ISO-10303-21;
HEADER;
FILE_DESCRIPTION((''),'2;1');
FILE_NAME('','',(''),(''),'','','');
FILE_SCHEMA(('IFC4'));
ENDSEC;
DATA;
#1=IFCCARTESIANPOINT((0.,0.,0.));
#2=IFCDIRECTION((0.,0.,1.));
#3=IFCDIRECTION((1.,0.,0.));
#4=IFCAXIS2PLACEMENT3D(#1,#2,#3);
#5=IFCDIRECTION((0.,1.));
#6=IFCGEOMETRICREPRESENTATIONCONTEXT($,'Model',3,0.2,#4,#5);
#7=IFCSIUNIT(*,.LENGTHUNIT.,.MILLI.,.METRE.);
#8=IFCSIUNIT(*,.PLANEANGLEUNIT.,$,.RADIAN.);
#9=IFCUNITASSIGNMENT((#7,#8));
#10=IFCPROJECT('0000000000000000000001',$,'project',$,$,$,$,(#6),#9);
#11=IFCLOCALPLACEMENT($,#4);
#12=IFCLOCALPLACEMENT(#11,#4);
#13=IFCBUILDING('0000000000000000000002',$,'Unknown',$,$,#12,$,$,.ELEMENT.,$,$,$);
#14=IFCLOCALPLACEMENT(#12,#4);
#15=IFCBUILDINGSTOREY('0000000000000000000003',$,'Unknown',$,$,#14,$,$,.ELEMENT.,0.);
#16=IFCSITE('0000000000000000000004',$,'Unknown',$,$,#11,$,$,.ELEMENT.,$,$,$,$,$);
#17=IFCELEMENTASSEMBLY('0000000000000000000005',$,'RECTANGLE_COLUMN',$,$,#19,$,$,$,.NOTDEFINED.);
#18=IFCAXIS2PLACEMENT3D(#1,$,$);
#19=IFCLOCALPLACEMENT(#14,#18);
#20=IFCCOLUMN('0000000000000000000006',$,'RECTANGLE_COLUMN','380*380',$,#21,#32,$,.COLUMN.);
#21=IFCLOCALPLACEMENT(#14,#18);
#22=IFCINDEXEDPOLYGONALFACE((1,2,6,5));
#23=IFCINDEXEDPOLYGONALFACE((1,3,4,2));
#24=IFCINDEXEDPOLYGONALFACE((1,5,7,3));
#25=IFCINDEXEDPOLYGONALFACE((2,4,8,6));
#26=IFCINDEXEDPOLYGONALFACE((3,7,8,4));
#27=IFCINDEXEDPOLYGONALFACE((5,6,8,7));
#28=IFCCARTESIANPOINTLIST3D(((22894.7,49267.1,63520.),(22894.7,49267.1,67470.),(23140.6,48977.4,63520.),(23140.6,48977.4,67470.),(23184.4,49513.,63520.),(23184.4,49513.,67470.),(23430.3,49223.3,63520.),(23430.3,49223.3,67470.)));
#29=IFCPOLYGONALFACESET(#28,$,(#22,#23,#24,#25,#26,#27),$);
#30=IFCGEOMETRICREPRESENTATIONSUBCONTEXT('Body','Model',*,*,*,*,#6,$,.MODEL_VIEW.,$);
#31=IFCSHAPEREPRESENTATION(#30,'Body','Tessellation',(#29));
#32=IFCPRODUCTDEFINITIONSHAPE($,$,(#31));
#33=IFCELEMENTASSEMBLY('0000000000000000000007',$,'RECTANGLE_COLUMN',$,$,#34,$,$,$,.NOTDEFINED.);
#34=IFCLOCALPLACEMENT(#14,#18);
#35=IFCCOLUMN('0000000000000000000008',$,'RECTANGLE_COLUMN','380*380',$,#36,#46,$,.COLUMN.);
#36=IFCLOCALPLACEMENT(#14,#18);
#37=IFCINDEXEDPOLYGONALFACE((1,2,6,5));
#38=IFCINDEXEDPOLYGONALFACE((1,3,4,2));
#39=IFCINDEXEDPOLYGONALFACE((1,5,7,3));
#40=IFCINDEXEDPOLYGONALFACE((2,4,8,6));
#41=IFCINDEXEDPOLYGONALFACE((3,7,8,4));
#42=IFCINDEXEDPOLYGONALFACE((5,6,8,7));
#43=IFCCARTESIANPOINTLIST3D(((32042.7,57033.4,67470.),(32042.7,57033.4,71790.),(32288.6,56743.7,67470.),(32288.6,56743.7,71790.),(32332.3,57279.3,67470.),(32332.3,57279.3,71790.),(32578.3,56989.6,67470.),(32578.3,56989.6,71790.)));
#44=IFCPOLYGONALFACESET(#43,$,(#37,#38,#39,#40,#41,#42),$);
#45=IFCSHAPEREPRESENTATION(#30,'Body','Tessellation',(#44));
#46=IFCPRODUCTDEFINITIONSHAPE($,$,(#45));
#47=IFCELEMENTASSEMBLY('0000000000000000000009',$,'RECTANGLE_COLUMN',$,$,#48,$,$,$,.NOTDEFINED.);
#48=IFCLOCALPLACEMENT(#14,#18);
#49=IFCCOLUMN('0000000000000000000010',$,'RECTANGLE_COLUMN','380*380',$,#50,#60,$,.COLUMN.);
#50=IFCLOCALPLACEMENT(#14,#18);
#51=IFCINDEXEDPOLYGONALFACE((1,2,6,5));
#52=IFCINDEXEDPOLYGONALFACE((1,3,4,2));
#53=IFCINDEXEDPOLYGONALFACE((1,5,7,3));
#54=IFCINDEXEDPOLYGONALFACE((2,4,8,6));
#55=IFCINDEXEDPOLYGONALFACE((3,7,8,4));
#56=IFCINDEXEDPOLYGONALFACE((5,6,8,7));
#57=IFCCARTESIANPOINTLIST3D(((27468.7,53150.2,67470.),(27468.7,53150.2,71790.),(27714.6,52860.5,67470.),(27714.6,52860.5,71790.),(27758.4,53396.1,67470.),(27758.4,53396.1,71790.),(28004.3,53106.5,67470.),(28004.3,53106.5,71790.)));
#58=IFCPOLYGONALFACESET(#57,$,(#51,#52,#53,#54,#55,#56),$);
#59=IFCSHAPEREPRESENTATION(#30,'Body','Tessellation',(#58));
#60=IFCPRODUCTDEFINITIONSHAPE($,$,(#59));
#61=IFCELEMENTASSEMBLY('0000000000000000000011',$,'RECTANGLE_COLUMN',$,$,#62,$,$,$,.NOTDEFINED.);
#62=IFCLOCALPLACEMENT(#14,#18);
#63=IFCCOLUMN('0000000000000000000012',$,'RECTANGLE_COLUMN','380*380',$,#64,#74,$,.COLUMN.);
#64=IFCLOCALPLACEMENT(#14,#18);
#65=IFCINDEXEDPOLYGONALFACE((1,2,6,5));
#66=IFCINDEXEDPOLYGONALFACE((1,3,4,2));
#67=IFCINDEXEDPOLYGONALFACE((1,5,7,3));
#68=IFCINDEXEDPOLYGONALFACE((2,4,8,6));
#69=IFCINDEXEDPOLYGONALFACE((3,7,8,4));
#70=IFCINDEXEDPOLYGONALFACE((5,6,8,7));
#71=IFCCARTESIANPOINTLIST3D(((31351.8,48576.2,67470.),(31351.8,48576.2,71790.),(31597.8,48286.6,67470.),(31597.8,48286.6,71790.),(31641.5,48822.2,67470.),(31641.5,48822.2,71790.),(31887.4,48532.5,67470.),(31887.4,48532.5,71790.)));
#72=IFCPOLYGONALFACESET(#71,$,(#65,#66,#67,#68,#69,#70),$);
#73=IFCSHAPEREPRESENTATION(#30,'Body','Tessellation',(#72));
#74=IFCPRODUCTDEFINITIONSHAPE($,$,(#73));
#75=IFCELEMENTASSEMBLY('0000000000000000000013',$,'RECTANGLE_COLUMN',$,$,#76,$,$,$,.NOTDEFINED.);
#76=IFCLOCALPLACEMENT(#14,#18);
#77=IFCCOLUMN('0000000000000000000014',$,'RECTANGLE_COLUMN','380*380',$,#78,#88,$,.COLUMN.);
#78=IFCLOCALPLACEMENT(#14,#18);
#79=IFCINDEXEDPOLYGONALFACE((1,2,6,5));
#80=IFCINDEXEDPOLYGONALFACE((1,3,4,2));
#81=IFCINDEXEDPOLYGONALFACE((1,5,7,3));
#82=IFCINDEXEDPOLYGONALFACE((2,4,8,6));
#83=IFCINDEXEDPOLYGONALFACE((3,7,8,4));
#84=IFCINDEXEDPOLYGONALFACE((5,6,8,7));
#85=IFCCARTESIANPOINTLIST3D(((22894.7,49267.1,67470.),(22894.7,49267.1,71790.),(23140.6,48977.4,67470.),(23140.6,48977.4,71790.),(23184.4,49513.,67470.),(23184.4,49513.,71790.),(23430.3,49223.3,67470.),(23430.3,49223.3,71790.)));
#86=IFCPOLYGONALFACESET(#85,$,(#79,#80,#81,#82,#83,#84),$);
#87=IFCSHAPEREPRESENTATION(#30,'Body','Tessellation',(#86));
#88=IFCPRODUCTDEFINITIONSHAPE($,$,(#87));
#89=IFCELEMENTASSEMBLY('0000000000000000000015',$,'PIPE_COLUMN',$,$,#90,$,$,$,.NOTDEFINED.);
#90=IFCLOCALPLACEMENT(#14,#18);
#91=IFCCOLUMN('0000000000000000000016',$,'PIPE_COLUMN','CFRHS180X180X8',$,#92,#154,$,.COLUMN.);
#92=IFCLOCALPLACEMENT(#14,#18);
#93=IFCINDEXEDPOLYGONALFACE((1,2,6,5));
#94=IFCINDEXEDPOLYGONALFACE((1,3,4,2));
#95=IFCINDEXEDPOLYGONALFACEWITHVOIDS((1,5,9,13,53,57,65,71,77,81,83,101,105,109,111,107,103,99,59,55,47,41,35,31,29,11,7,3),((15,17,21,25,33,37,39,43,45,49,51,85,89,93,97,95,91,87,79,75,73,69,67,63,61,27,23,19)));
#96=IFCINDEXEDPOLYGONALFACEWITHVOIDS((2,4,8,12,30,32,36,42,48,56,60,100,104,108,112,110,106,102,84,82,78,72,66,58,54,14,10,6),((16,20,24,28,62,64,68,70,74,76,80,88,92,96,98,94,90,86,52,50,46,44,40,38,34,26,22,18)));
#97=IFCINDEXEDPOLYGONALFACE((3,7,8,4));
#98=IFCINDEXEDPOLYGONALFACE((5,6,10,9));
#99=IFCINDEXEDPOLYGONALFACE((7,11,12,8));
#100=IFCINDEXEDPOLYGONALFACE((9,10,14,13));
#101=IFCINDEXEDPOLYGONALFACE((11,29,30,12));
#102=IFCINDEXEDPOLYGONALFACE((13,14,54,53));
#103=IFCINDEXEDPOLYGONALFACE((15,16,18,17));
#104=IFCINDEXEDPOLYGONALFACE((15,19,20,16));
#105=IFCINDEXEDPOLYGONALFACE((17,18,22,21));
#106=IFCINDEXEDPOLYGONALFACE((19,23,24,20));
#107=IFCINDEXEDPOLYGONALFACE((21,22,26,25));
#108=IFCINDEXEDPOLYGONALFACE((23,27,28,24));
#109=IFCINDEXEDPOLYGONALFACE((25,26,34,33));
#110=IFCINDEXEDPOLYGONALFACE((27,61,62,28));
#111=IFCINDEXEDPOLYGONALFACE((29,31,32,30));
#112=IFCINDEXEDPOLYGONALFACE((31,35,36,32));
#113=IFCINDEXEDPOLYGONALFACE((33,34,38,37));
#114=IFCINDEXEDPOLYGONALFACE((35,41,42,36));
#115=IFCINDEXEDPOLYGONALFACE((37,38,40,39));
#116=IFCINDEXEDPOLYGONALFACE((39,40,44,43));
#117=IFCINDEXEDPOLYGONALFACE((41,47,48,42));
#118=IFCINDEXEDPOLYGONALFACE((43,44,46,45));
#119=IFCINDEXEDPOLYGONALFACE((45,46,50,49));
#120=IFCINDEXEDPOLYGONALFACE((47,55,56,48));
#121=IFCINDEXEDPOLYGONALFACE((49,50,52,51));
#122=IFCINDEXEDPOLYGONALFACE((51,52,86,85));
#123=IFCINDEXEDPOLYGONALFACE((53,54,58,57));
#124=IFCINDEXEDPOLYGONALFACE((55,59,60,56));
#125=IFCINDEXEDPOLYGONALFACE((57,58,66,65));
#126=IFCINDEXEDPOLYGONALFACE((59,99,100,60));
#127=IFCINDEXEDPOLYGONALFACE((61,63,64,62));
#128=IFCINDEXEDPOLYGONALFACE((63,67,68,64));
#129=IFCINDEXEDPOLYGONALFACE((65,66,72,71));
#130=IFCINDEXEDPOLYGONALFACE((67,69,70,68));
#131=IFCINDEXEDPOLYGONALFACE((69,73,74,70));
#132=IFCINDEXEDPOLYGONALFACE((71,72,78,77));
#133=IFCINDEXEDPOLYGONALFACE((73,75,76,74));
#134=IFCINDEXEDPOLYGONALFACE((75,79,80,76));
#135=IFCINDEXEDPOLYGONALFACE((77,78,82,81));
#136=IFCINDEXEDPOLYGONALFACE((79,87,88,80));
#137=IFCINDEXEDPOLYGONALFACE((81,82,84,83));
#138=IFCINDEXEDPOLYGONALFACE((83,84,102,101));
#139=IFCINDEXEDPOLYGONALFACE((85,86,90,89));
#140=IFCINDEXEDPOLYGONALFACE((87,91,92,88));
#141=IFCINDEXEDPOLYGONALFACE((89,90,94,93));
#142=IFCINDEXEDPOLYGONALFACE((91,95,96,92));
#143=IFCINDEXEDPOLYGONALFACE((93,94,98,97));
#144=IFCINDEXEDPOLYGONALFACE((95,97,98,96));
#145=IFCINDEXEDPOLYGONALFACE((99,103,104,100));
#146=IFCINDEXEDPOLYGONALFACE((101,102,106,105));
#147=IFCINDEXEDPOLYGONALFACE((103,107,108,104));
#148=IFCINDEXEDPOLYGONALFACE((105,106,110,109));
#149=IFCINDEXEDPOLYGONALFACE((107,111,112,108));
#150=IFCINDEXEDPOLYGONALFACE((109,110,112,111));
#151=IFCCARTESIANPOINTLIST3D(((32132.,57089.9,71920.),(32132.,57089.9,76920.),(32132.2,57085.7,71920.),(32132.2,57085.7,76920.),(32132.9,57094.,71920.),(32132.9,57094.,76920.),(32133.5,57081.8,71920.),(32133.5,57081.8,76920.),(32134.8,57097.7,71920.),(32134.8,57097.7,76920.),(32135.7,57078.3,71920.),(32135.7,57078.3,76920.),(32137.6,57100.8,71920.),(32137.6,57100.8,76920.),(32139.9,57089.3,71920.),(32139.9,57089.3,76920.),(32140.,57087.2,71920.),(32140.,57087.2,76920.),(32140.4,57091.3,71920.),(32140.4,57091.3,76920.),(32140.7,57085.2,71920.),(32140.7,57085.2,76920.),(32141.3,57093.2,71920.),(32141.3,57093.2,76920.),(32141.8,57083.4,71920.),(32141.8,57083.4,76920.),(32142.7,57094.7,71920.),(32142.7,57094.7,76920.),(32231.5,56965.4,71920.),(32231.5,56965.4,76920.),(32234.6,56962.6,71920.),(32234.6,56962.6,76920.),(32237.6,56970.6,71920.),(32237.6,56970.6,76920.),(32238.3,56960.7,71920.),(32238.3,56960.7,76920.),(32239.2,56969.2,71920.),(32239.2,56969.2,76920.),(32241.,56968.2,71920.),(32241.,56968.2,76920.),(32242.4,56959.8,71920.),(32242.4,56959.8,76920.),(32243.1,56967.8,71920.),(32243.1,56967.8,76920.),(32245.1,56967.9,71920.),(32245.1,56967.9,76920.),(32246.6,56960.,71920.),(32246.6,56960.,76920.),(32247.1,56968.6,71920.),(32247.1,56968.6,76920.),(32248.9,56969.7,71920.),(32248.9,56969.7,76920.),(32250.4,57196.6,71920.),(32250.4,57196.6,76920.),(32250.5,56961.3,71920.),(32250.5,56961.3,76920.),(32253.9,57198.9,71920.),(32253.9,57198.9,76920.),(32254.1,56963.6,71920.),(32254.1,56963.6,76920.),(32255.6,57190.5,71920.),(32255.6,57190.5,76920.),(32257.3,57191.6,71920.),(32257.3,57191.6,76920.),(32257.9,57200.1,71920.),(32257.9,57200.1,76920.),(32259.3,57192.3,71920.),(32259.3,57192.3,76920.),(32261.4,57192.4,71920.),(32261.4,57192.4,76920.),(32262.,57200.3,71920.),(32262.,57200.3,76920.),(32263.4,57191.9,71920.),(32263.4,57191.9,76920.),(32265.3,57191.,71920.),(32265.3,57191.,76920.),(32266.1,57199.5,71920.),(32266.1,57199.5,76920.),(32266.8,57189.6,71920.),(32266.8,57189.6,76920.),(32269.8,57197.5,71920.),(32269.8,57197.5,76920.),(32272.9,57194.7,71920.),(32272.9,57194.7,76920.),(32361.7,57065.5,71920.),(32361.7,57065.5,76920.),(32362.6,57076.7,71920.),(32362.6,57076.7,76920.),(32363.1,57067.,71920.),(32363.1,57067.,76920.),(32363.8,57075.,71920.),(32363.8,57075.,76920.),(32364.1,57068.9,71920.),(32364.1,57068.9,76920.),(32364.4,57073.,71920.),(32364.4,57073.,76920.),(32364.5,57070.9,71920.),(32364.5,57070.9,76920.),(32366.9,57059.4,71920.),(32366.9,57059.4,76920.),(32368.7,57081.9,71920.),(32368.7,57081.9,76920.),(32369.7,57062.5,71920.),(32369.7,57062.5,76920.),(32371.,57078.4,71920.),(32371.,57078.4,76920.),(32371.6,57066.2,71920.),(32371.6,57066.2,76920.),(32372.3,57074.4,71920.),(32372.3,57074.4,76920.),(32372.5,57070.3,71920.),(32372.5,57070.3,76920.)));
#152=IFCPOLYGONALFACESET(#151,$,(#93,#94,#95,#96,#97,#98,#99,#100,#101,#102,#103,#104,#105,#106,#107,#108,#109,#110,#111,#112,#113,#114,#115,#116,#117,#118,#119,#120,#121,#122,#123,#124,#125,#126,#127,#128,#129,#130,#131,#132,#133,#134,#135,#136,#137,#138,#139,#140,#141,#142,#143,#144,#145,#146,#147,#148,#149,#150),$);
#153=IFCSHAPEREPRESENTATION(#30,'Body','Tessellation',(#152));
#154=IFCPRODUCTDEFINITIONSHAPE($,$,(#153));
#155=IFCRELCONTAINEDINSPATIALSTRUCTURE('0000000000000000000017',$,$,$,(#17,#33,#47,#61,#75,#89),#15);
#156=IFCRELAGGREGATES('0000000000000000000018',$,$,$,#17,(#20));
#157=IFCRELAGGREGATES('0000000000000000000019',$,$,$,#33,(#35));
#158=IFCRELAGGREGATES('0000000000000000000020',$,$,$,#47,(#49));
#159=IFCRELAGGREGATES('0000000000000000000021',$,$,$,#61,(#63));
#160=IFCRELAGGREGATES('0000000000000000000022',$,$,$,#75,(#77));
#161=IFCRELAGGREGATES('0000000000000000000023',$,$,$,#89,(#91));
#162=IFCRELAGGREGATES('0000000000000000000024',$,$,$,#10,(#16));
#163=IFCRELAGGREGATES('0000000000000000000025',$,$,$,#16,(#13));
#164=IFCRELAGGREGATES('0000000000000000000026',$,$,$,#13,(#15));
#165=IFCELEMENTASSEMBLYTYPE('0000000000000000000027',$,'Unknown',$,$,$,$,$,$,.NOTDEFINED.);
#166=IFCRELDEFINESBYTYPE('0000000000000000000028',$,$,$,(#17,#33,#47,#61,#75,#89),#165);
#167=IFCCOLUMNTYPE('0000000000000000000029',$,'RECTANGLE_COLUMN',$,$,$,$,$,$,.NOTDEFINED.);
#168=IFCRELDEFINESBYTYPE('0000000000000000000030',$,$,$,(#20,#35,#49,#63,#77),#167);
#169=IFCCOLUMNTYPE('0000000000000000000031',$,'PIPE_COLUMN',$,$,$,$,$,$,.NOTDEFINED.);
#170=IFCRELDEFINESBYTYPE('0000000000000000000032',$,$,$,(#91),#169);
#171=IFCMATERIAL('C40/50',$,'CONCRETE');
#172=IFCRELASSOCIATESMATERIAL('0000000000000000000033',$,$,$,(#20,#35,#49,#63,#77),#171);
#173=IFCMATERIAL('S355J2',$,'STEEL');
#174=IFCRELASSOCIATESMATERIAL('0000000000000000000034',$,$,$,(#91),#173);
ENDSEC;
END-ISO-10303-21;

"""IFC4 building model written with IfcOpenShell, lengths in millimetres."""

from ifc_helpers import new_model, si_unit, direction, frame, origin_with_axes, origin_2d_with_axis, place, context, subcontext, project, spatial, rectangle, hollow_rectangle, extrude, material, material_profile, profile_set, profile_usage, type_object, element, aggregate, save


model = new_model("IFC4")

# Units and contexts
model_context = context("Model", 3, precision=0.2, world=origin_with_axes(), true_north=direction((0.0, 1.0)))
body_context = subcontext(model_context, "Body", "Model", "MODEL_VIEW")
ifc_project = project(units=[si_unit("LENGTHUNIT", "METRE", prefix="MILLI"), si_unit("PLANEANGLEUNIT", "RADIAN")], contexts=[model_context])

# Site, building, storey
site_placement = place(None, origin_with_axes())
site = spatial("IfcSite", under=ifc_project, at=site_placement, Name="Unknown", CompositionType="ELEMENT")
building_placement = place(site_placement, origin_with_axes())
building = spatial("IfcBuilding", under=site, at=building_placement, Name="Unknown", CompositionType="ELEMENT")
storey_placement = place(building_placement, origin_with_axes())
storey = spatial("IfcBuildingStorey", under=building, at=storey_placement, Name="Unknown", CompositionType="ELEMENT", Elevation=0.0)

# Element assemblies, columns
element_assembly_type = type_object("IfcElementAssemblyType", Name="Unknown", PredefinedType="NOTDEFINED")
assembly_1_placement = place(storey_placement, frame((23162.5, 49245.2, 63520.0), z_axis=(-0.762329, -0.64719, 0.0), x_axis=(0.0, 0.0, 1.0)))
assembly_1 = element("IfcElementAssembly", 1, at=assembly_1_placement, inside=storey, type_object=element_assembly_type, Name="RECTANGLE_COLUMN", PredefinedType="NOTDEFINED")
ifc_material_1 = material(Name="C40/50", Category="CONCRETE")
ifc_material_profile_1 = material_profile(ifc_material_1, rectangle(XDim=380.0, YDim=380.0, at=origin_2d_with_axis()), Name="380*380")
ifc_profile_set_1 = profile_set([ifc_material_profile_1])
ifc_profile_usage_1 = profile_usage(ifc_profile_set_1, cardinal=5)
column_type_1 = type_object("IfcColumnType", Name="RECTANGLE_COLUMN")
column_1_placement = place(assembly_1_placement, origin_with_axes())
column_1 = element("IfcColumn", 2, at=column_1_placement, type_object=column_type_1, material=ifc_profile_usage_1, Name="RECTANGLE_COLUMN", Description="380*380", PredefinedType="COLUMN", context=body_context, shape_type="SolidModel", body=[
    extrude(rectangle(XDim=380.0, YDim=380.0, at=origin_2d_with_axis()), frame((0.0, 0.0, 0.0), z_axis=(-1.0, 0.0, 0.0), x_axis=(0.0, 0.0, 1.0)), (0.0, 0.0, -1.0), 3950.0),
])
aggregate(assembly_1, [column_1])
assembly_2_placement = place(storey_placement, frame((32310.5, 57011.5, 67470.0), z_axis=(-0.762329, -0.64719, 0.0), x_axis=(0.0, 0.0, 1.0)))
assembly_2 = element("IfcElementAssembly", 3, at=assembly_2_placement, inside=storey, type_object=element_assembly_type, Name="RECTANGLE_COLUMN", PredefinedType="NOTDEFINED")
column_2_placement = place(assembly_2_placement, origin_with_axes())
column_2 = element("IfcColumn", 4, at=column_2_placement, type_object=column_type_1, material=ifc_profile_usage_1, Name="RECTANGLE_COLUMN", Description="380*380", PredefinedType="COLUMN", context=body_context, shape_type="SolidModel", body=[
    extrude(rectangle(XDim=380.0, YDim=380.0, at=origin_2d_with_axis()), frame((0.0, 0.0, 0.0), z_axis=(-1.0, 0.0, 0.0), x_axis=(0.0, 0.0, 1.0)), (0.0, 0.0, -1.0), 4320.0),
])
aggregate(assembly_2, [column_2])
assembly_3_placement = place(storey_placement, frame((27736.5, 53128.3, 67470.0), z_axis=(-0.762329, -0.64719, 0.0), x_axis=(0.0, 0.0, 1.0)))
assembly_3 = element("IfcElementAssembly", 5, at=assembly_3_placement, inside=storey, type_object=element_assembly_type, Name="RECTANGLE_COLUMN", PredefinedType="NOTDEFINED")
column_3_placement = place(assembly_3_placement, origin_with_axes())
column_3 = element("IfcColumn", 6, at=column_3_placement, type_object=column_type_1, material=ifc_profile_usage_1, Name="RECTANGLE_COLUMN", Description="380*380", PredefinedType="COLUMN", context=body_context, shape_type="SolidModel", body=[
    extrude(rectangle(XDim=380.0, YDim=380.0, at=origin_2d_with_axis()), frame((0.0, 0.0, 0.0), z_axis=(-1.0, 0.0, 0.0), x_axis=(0.0, 0.0, 1.0)), (0.0, 0.0, -1.0), 4320.0),
])
aggregate(assembly_3, [column_3])
assembly_4_placement = place(storey_placement, frame((31619.6, 48554.4, 67470.0), z_axis=(-0.762329, -0.64719, 0.0), x_axis=(0.0, 0.0, 1.0)))
assembly_4 = element("IfcElementAssembly", 7, at=assembly_4_placement, inside=storey, type_object=element_assembly_type, Name="RECTANGLE_COLUMN", PredefinedType="NOTDEFINED")
column_4_placement = place(assembly_4_placement, origin_with_axes())
column_4 = element("IfcColumn", 8, at=column_4_placement, type_object=column_type_1, material=ifc_profile_usage_1, Name="RECTANGLE_COLUMN", Description="380*380", PredefinedType="COLUMN", context=body_context, shape_type="SolidModel", body=[
    extrude(rectangle(XDim=380.0, YDim=380.0, at=origin_2d_with_axis()), frame((0.0, 0.0, 0.0), z_axis=(-1.0, 0.0, 0.0), x_axis=(0.0, 0.0, 1.0)), (0.0, 0.0, -1.0), 4320.0),
])
aggregate(assembly_4, [column_4])
assembly_5_placement = place(storey_placement, frame((23162.5, 49245.2, 67470.0), z_axis=(-0.762329, -0.64719, 0.0), x_axis=(0.0, 0.0, 1.0)))
assembly_5 = element("IfcElementAssembly", 9, at=assembly_5_placement, inside=storey, type_object=element_assembly_type, Name="RECTANGLE_COLUMN", PredefinedType="NOTDEFINED")
column_5_placement = place(assembly_5_placement, origin_with_axes())
column_5 = element("IfcColumn", 10, at=column_5_placement, type_object=column_type_1, material=ifc_profile_usage_1, Name="RECTANGLE_COLUMN", Description="380*380", PredefinedType="COLUMN", context=body_context, shape_type="SolidModel", body=[
    extrude(rectangle(XDim=380.0, YDim=380.0, at=origin_2d_with_axis()), frame((0.0, 0.0, 0.0), z_axis=(-1.0, 0.0, 0.0), x_axis=(0.0, 0.0, 1.0)), (0.0, 0.0, -1.0), 4320.0),
])
aggregate(assembly_5, [column_5])
assembly_6_placement = place(storey_placement, frame((32252.2, 57080.1, 71920.0), z_axis=(-0.762329, -0.64719, 0.0), x_axis=(0.0, 0.0, 1.0)))
assembly_6 = element("IfcElementAssembly", 11, at=assembly_6_placement, inside=storey, type_object=element_assembly_type, Name="PIPE_COLUMN", PredefinedType="NOTDEFINED")
ifc_material_2 = material(Name="S355J2", Category="STEEL")
ifc_material_profile_2 = material_profile(ifc_material_2, hollow_rectangle(XDim=180.0, YDim=180.0, WallThickness=8.0, InnerFilletRadius=8.0, OuterFilletRadius=16.0, at=origin_2d_with_axis()), Name="CFRHS180X180X8")
ifc_profile_set_2 = profile_set([ifc_material_profile_2])
ifc_profile_usage_2 = profile_usage(ifc_profile_set_2, cardinal=6)
column_type_2 = type_object("IfcColumnType", Name="PIPE_COLUMN")
column_6_placement = place(assembly_6_placement, origin_with_axes())
column_6 = element("IfcColumn", 12, at=column_6_placement, type_object=column_type_2, material=ifc_profile_usage_2, Name="PIPE_COLUMN", Description="CFRHS180X180X8", PredefinedType="COLUMN", context=body_context, shape_type="SolidModel", body=[
    extrude(hollow_rectangle(XDim=180.0, YDim=180.0, WallThickness=8.0, InnerFilletRadius=8.0, OuterFilletRadius=16.0, at=origin_2d_with_axis()), frame((0.0, 0.0, 0.0), z_axis=(-1.0, 0.0, 0.0), x_axis=(0.0, 0.0, 1.0)), (0.0, 0.0, -1.0), 5000.0),
])
aggregate(assembly_6, [column_6])

save(model, "model.ifc")
